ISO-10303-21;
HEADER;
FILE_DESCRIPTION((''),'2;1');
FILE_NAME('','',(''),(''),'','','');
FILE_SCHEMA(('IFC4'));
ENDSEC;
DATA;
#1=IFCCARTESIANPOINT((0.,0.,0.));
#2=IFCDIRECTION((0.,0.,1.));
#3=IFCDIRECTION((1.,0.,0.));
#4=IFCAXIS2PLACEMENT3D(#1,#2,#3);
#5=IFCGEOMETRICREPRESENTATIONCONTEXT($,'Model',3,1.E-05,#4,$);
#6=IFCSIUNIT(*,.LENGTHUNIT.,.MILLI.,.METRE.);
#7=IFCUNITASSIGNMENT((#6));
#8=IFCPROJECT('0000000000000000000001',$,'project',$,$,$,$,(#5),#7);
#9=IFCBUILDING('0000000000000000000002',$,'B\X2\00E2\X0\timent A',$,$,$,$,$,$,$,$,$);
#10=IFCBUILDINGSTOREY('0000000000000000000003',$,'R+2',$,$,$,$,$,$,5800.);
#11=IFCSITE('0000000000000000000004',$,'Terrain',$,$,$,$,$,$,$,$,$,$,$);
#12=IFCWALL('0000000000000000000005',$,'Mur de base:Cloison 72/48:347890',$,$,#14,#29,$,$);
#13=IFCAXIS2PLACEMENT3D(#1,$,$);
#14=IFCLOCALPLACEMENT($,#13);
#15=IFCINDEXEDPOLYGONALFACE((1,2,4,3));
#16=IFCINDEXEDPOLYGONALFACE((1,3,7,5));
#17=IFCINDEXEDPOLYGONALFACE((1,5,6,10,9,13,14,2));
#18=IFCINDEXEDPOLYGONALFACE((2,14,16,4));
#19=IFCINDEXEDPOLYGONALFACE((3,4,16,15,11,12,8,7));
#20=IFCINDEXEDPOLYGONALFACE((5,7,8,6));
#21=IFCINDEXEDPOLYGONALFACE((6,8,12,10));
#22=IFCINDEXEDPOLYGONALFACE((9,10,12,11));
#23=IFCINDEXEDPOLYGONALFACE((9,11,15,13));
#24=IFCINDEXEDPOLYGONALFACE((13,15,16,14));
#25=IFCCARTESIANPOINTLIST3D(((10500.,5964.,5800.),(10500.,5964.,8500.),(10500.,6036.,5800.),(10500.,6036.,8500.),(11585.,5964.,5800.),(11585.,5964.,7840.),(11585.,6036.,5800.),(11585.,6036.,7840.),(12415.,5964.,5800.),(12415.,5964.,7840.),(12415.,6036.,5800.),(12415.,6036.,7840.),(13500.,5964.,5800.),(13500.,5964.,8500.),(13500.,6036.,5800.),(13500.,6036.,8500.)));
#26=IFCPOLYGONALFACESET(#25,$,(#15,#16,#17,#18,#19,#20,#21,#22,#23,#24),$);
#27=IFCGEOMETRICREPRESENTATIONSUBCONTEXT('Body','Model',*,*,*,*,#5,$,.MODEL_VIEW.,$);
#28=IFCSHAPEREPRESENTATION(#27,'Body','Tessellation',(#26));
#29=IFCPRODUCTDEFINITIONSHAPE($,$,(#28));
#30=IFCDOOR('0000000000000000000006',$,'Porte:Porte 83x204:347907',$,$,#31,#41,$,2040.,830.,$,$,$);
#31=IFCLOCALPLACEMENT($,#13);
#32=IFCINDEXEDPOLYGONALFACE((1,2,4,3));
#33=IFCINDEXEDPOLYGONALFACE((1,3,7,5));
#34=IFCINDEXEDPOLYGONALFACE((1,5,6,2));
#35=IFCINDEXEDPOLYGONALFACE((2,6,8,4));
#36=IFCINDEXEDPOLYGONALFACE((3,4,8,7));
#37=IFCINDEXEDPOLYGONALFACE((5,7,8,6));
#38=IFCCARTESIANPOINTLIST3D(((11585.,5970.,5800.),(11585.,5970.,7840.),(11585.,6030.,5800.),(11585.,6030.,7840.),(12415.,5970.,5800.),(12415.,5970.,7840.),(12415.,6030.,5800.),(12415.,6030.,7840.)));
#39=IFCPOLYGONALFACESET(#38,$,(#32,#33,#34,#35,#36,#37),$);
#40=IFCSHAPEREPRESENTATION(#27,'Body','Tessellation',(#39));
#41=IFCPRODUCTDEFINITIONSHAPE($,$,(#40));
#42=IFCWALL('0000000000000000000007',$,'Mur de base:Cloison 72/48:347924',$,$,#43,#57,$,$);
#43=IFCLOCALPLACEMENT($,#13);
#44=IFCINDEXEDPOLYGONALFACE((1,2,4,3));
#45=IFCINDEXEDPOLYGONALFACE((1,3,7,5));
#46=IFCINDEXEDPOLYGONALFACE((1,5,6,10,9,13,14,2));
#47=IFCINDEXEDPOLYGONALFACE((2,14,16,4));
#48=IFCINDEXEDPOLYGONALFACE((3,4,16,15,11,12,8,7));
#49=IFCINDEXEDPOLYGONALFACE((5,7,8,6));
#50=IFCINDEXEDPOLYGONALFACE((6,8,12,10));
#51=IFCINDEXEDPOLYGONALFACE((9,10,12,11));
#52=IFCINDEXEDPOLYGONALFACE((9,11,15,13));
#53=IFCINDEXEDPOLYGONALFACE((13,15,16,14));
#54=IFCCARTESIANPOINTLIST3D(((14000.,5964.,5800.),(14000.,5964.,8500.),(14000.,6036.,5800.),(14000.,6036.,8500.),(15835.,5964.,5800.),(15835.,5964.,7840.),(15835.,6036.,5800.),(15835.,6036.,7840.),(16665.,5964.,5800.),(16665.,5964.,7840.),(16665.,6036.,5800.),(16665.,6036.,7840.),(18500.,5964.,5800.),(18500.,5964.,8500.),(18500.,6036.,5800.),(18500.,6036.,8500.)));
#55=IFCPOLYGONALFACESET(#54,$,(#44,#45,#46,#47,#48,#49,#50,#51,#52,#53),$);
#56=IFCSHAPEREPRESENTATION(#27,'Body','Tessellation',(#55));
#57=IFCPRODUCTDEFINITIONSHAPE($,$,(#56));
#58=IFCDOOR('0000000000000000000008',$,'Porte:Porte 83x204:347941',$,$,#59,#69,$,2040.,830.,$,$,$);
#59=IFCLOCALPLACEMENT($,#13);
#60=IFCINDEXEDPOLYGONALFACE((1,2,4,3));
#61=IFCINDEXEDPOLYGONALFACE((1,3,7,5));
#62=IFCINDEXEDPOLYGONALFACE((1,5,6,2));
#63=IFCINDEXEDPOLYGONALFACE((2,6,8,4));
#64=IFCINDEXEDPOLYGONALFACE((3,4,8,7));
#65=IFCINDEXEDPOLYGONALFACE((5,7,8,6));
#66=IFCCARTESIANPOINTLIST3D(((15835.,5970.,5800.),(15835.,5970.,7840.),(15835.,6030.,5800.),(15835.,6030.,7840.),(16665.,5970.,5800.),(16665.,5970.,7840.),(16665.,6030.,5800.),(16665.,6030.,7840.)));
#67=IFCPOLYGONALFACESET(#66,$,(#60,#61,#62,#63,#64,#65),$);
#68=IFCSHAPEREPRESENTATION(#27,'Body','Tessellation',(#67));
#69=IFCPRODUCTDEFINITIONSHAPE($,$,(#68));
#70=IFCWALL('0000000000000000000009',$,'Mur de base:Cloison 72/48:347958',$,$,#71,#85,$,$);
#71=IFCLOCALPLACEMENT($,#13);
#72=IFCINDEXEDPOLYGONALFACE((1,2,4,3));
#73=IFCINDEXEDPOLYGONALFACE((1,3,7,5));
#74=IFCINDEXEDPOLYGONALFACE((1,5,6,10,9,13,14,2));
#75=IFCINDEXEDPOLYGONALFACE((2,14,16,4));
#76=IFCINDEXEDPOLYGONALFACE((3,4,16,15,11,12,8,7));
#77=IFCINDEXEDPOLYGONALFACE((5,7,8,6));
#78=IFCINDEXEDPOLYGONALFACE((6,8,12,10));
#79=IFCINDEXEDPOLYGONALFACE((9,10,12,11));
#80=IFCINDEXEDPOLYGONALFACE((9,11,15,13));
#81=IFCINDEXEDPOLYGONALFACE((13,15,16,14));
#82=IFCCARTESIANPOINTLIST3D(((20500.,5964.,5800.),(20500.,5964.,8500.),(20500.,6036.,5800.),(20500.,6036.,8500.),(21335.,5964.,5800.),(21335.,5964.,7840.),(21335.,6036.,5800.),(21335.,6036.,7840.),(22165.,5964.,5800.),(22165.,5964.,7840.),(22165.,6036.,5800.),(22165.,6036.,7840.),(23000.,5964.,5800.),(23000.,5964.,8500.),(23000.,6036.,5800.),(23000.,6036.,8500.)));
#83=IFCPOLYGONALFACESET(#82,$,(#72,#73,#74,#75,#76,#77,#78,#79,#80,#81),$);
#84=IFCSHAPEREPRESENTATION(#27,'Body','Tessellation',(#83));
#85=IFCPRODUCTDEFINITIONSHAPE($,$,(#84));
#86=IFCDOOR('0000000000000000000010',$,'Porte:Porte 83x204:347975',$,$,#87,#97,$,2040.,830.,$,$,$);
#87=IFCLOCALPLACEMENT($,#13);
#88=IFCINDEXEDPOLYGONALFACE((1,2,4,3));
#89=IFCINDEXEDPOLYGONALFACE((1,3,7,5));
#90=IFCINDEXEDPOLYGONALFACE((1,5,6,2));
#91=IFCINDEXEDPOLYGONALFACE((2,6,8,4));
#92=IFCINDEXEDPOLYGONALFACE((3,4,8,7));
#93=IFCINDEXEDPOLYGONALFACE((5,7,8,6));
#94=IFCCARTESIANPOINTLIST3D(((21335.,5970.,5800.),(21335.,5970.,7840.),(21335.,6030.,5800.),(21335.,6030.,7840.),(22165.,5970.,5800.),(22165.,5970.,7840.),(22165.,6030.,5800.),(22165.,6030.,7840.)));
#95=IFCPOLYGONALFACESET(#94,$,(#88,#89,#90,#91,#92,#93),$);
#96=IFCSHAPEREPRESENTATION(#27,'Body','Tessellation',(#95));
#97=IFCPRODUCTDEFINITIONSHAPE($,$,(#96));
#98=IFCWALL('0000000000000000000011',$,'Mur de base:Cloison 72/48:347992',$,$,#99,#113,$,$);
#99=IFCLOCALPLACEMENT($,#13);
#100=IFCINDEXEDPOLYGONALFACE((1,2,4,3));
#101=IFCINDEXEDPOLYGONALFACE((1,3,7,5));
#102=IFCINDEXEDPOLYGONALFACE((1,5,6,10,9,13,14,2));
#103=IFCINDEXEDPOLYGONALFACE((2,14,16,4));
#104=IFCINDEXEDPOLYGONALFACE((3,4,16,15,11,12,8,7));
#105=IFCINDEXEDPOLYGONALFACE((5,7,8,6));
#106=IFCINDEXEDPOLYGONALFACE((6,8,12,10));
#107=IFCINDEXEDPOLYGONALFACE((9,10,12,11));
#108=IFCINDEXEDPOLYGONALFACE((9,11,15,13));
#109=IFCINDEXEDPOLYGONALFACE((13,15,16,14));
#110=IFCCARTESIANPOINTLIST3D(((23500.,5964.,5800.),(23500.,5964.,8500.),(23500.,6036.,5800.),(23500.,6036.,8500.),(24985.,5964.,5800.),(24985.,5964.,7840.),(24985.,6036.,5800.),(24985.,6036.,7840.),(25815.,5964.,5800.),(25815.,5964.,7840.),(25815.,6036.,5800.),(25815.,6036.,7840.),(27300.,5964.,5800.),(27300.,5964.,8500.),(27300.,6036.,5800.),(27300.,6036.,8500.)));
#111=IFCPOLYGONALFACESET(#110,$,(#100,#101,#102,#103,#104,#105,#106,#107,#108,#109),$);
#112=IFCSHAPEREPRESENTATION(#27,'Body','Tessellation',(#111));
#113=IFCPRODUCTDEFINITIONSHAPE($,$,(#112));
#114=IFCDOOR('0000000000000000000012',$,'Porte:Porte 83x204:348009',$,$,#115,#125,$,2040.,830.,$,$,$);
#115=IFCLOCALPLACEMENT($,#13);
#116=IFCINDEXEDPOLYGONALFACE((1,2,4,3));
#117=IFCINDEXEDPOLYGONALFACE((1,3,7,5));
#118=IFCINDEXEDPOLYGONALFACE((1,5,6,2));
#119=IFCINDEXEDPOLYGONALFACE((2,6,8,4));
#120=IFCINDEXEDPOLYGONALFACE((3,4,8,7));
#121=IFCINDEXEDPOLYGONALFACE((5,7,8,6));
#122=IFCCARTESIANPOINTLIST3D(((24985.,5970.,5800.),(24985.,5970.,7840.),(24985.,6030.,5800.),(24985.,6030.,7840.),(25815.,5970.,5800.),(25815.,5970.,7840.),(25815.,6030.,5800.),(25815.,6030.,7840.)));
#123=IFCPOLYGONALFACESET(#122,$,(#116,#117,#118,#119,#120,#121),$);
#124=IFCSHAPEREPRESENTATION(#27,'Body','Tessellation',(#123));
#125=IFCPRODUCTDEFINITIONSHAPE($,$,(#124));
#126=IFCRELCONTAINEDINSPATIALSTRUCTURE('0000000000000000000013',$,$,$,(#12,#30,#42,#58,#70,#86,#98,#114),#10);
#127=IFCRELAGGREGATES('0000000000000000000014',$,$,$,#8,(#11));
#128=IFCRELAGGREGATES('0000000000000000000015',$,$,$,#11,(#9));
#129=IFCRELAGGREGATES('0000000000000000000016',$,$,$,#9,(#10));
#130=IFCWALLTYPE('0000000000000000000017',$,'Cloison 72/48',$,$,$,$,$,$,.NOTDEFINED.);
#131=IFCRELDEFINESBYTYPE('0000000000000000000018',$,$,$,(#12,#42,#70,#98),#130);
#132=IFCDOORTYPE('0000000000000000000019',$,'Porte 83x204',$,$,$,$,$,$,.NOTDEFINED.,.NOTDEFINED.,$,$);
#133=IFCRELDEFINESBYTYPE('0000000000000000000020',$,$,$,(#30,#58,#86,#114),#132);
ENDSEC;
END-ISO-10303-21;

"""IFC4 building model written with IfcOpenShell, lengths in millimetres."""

from ifc_helpers import new_model, si_unit, frame, frame_2d, origin_with_axes, place, context, subcontext, project, spatial, rectangle, extrude, type_object, element, fill, save


model = new_model("IFC4")

# Units and contexts
model_context = context("Model", 3, precision=1e-05, world=origin_with_axes())
body_context = subcontext(model_context, "Body", "Model", "MODEL_VIEW")
ifc_project = project(units=[si_unit("LENGTHUNIT", "METRE", prefix="MILLI")], contexts=[model_context])

# Site, building, storey
site = spatial("IfcSite", under=ifc_project, Name="Terrain")
building = spatial("IfcBuilding", under=site, Name="Bâtiment A")
storey = spatial("IfcBuildingStorey", under=building, Name="R+2", Elevation=5800.0)

# Walls, openings, doors
door_type = type_object("IfcDoorType", Name="Porte 83x204", OperationType="NOTDEFINED", PredefinedType="NOTDEFINED")
wall_type_1 = type_object("IfcWallType", Name="Cloison 72/48", PredefinedType="NOTDEFINED")
wall_1_placement = place(None, origin_with_axes())
wall_1 = element("IfcWall", 1, at=wall_1_placement, inside=storey, type_object=wall_type_1, Name="Mur de base:Cloison 72/48:347890", context=body_context, shape_type="SweptSolid", body=[
    extrude(rectangle(XDim=3000.0, YDim=72.0, at=frame_2d((12000.0, 6000.0))), frame((0.0, 0.0, 5800.0), z_axis=(0.0, 0.0, 1.0), x_axis=(1.0, 0.0, 0.0)), (0.0, 0.0, 1.0), 2700.0),
])
opening_1_placement = place(None, origin_with_axes())
opening_1 = element("IfcOpeningElement", 2, at=opening_1_placement, cuts=wall_1, context=body_context, shape_type="SweptSolid", body=[
    extrude(rectangle(XDim=830.0, YDim=192.0, at=frame_2d((12000.0, 6000.0))), frame((0.0, 0.0, 5800.0), z_axis=(0.0, 0.0, 1.0), x_axis=(1.0, 0.0, 0.0)), (0.0, 0.0, 1.0), 2040.0),
])
door_1_placement = place(None, origin_with_axes())
door_1 = element("IfcDoor", 3, at=door_1_placement, inside=storey, type_object=door_type, Name="Porte:Porte 83x204:347907", OverallHeight=2040.0, OverallWidth=830.0, context=body_context, shape_type="SweptSolid", body=[
    extrude(rectangle(XDim=830.0, YDim=60.0, at=frame_2d((12000.0, 6000.0))), frame((0.0, 0.0, 5800.0), z_axis=(0.0, 0.0, 1.0), x_axis=(1.0, 0.0, 0.0)), (0.0, 0.0, 1.0), 2040.0),
])
fill(opening_1, door_1)
wall_2_placement = place(None, origin_with_axes())
wall_2 = element("IfcWall", 4, at=wall_2_placement, inside=storey, type_object=wall_type_1, Name="Mur de base:Cloison 72/48:347924", context=body_context, shape_type="SweptSolid", body=[
    extrude(rectangle(XDim=4500.0, YDim=72.0, at=frame_2d((16250.0, 6000.0))), frame((0.0, 0.0, 5800.0), z_axis=(0.0, 0.0, 1.0), x_axis=(1.0, 0.0, 0.0)), (0.0, 0.0, 1.0), 2700.0),
])
opening_2_placement = place(None, origin_with_axes())
opening_2 = element("IfcOpeningElement", 5, at=opening_2_placement, cuts=wall_2, context=body_context, shape_type="SweptSolid", body=[
    extrude(rectangle(XDim=830.0, YDim=192.0, at=frame_2d((16250.0, 6000.0))), frame((0.0, 0.0, 5800.0), z_axis=(0.0, 0.0, 1.0), x_axis=(1.0, 0.0, 0.0)), (0.0, 0.0, 1.0), 2040.0),
])
door_2_placement = place(None, origin_with_axes())
door_2 = element("IfcDoor", 6, at=door_2_placement, inside=storey, type_object=door_type, Name="Porte:Porte 83x204:347941", OverallHeight=2040.0, OverallWidth=830.0, context=body_context, shape_type="SweptSolid", body=[
    extrude(rectangle(XDim=830.0, YDim=60.0, at=frame_2d((16250.0, 6000.0))), frame((0.0, 0.0, 5800.0), z_axis=(0.0, 0.0, 1.0), x_axis=(1.0, 0.0, 0.0)), (0.0, 0.0, 1.0), 2040.0),
])
fill(opening_2, door_2)
wall_3_placement = place(None, origin_with_axes())
wall_3 = element("IfcWall", 7, at=wall_3_placement, inside=storey, type_object=wall_type_1, Name="Mur de base:Cloison 72/48:347958", context=body_context, shape_type="SweptSolid", body=[
    extrude(rectangle(XDim=2500.0, YDim=72.0, at=frame_2d((21750.0, 6000.0))), frame((0.0, 0.0, 5800.0), z_axis=(0.0, 0.0, 1.0), x_axis=(1.0, 0.0, 0.0)), (0.0, 0.0, 1.0), 2700.0),
])
opening_3_placement = place(None, origin_with_axes())
opening_3 = element("IfcOpeningElement", 8, at=opening_3_placement, cuts=wall_3, context=body_context, shape_type="SweptSolid", body=[
    extrude(rectangle(XDim=830.0, YDim=192.0, at=frame_2d((21750.0, 6000.0))), frame((0.0, 0.0, 5800.0), z_axis=(0.0, 0.0, 1.0), x_axis=(1.0, 0.0, 0.0)), (0.0, 0.0, 1.0), 2040.0),
])
door_3_placement = place(None, origin_with_axes())
door_3 = element("IfcDoor", 9, at=door_3_placement, inside=storey, type_object=door_type, Name="Porte:Porte 83x204:347975", OverallHeight=2040.0, OverallWidth=830.0, context=body_context, shape_type="SweptSolid", body=[
    extrude(rectangle(XDim=830.0, YDim=60.0, at=frame_2d((21750.0, 6000.0))), frame((0.0, 0.0, 5800.0), z_axis=(0.0, 0.0, 1.0), x_axis=(1.0, 0.0, 0.0)), (0.0, 0.0, 1.0), 2040.0),
])
fill(opening_3, door_3)
wall_4_placement = place(None, origin_with_axes())
wall_4 = element("IfcWall", 10, at=wall_4_placement, inside=storey, type_object=wall_type_1, Name="Mur de base:Cloison 72/48:347992", context=body_context, shape_type="SweptSolid", body=[
    extrude(rectangle(XDim=3800.0, YDim=72.0, at=frame_2d((25400.0, 6000.0))), frame((0.0, 0.0, 5800.0), z_axis=(0.0, 0.0, 1.0), x_axis=(1.0, 0.0, 0.0)), (0.0, 0.0, 1.0), 2700.0),
])
opening_4_placement = place(None, origin_with_axes())
opening_4 = element("IfcOpeningElement", 11, at=opening_4_placement, cuts=wall_4, context=body_context, shape_type="SweptSolid", body=[
    extrude(rectangle(XDim=830.0, YDim=192.0, at=frame_2d((25400.0, 6000.0))), frame((0.0, 0.0, 5800.0), z_axis=(0.0, 0.0, 1.0), x_axis=(1.0, 0.0, 0.0)), (0.0, 0.0, 1.0), 2040.0),
])
door_4_placement = place(None, origin_with_axes())
door_4 = element("IfcDoor", 12, at=door_4_placement, inside=storey, type_object=door_type, Name="Porte:Porte 83x204:348009", OverallHeight=2040.0, OverallWidth=830.0, context=body_context, shape_type="SweptSolid", body=[
    extrude(rectangle(XDim=830.0, YDim=60.0, at=frame_2d((25400.0, 6000.0))), frame((0.0, 0.0, 5800.0), z_axis=(0.0, 0.0, 1.0), x_axis=(1.0, 0.0, 0.0)), (0.0, 0.0, 1.0), 2040.0),
])
fill(opening_4, door_4)

save(model, "model.ifc")
